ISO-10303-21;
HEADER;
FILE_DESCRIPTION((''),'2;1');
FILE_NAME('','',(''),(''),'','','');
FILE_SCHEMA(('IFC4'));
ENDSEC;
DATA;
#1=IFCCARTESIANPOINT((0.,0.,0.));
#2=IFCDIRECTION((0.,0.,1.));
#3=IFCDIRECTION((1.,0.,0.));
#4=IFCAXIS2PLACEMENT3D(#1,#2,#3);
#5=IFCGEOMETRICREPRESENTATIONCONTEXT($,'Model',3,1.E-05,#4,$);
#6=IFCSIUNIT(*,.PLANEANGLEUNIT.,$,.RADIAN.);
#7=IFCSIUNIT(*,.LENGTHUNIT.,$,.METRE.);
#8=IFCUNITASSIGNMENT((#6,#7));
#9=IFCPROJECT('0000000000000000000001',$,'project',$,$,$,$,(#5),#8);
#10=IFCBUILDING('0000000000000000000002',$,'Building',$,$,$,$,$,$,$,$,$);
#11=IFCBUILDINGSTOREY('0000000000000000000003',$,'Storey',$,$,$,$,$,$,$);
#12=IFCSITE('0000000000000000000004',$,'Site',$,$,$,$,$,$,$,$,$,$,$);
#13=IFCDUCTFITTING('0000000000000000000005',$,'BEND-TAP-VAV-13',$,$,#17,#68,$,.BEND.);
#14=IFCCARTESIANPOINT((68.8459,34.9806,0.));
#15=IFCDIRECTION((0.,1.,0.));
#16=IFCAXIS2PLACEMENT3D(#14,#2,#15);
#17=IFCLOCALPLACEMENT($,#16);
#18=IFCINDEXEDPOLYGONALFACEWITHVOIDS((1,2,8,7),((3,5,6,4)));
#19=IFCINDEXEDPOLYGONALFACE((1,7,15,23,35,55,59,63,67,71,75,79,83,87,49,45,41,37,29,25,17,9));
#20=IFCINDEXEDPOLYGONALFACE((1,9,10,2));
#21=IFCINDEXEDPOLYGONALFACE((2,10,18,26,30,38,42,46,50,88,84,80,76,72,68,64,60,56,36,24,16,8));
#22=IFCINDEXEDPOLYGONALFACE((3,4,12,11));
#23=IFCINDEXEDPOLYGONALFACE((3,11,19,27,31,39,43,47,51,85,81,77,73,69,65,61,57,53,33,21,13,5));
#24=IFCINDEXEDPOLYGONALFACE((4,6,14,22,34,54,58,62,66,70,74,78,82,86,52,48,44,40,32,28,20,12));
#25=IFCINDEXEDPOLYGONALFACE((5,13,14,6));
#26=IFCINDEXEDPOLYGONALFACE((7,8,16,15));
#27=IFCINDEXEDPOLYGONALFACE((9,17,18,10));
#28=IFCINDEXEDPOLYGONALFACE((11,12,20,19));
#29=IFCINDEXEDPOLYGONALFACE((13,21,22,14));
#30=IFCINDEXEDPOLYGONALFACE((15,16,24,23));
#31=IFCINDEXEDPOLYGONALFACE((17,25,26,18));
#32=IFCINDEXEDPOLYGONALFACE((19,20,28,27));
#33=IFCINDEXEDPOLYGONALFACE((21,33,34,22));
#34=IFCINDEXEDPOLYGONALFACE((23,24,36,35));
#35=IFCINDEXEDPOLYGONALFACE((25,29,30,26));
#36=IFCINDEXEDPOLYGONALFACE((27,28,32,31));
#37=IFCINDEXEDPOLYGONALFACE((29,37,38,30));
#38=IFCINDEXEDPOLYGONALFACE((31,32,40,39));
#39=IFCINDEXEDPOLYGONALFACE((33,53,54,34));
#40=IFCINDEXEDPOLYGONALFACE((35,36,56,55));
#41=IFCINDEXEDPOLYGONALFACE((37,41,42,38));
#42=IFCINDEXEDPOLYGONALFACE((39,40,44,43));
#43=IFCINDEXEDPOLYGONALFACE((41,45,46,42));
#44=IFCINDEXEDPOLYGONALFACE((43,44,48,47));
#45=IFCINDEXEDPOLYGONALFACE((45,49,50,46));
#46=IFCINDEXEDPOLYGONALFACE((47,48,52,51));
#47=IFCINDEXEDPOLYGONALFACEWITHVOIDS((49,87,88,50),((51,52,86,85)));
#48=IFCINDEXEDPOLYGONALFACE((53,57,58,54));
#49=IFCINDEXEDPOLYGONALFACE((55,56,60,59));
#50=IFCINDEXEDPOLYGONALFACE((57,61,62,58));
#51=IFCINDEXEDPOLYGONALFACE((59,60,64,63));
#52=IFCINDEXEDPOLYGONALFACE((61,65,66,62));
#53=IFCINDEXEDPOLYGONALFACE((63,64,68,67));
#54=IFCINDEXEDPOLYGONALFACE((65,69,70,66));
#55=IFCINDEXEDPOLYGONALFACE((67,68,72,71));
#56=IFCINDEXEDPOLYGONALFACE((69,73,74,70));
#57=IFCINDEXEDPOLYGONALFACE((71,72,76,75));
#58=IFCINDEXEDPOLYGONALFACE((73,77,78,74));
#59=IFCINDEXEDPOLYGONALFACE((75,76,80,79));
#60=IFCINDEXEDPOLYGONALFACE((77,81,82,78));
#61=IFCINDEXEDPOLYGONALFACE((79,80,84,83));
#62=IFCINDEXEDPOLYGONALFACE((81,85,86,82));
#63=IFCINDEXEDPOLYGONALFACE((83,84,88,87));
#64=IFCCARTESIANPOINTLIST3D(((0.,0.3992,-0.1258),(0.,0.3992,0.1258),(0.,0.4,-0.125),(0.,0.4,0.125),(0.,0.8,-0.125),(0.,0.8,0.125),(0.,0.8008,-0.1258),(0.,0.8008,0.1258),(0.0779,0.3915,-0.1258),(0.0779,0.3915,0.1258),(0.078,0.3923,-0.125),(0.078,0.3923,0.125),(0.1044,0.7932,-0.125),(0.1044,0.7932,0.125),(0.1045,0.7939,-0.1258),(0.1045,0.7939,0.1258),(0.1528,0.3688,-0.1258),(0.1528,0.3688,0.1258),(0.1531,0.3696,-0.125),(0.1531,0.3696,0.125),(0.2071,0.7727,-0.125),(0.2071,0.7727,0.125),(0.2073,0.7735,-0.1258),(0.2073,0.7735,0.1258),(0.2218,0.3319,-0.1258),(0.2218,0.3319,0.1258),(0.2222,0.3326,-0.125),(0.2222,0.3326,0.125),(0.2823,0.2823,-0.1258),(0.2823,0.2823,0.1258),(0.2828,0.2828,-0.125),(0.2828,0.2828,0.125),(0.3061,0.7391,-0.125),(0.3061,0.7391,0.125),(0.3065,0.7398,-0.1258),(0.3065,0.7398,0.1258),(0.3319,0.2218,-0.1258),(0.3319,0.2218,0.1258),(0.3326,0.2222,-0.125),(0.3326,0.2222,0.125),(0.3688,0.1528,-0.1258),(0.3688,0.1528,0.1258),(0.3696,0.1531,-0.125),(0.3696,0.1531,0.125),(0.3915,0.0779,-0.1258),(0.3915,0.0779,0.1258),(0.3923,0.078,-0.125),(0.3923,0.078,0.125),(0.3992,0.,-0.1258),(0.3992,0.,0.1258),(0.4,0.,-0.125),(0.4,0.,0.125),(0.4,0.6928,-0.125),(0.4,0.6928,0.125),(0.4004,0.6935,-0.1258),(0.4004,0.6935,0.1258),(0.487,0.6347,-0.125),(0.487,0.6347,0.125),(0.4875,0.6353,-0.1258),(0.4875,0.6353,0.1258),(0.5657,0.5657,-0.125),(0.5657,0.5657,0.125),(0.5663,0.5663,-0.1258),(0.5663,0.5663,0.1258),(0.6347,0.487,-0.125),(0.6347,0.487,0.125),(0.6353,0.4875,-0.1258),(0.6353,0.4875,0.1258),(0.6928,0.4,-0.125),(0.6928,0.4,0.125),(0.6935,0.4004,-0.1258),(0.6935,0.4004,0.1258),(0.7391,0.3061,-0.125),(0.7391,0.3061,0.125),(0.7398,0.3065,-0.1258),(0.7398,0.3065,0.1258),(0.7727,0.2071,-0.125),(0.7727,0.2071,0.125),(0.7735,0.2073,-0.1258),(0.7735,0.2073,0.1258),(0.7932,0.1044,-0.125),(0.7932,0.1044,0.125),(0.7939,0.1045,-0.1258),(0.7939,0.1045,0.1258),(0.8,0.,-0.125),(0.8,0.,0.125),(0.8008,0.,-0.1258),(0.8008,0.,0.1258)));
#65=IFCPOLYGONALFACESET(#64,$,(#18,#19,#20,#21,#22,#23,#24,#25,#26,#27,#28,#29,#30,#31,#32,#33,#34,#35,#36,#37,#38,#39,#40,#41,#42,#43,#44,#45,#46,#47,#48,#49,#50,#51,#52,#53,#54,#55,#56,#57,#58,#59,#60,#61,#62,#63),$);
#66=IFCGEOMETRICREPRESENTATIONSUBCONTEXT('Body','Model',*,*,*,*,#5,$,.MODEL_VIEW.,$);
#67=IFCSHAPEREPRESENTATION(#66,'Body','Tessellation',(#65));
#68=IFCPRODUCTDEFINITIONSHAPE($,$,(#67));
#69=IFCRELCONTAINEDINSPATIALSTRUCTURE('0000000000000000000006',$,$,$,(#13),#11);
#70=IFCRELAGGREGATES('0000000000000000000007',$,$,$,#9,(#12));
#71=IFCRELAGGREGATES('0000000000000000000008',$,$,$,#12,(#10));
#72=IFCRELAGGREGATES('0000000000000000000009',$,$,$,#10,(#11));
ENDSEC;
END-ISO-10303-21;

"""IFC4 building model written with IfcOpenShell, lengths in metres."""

from ifc_helpers import new_model, entity, si_unit, frame, origin_with_axes, place, context, subcontext, project, spatial, element, save


model = new_model("IFC4")

# Units and contexts
model_context = context("Model", 3, precision=1e-05, world=origin_with_axes())
body_context = subcontext(model_context, "Body", "Model", "MODEL_VIEW")
ifc_project = project(units=[si_unit("PLANEANGLEUNIT", "RADIAN"), si_unit("LENGTHUNIT", "METRE")], contexts=[model_context])

# Site, building, storey
site = spatial("IfcSite", under=ifc_project, Name="Site")
building = spatial("IfcBuilding", under=site, Name="Building")
storey = spatial("IfcBuildingStorey", under=building, Name="Storey")

# Duct fitting
duct_fitting_1_placement = place(None, frame((68.8459, 34.9806, 0.0), z_axis=(0.0, 0.0, 1.0), x_axis=(0.0, 1.0, 0.0)))
cartesian_point_1 = entity("IfcCartesianPoint", [0.0, 0.0, 0.0])
element("IfcDuctFitting", 1, at=duct_fitting_1_placement, inside=storey, Name="BEND-TAP-VAV-13", PredefinedType="BEND", context=body_context, shape_type="SweptSolid", body=[
    entity("IfcRevolvedAreaSolid", entity("IfcRectangleHollowProfileDef", "AREA", None, entity("IfcAxis2Placement2D", entity("IfcCartesianPoint", [0.6, 0.0])), 0.4016, 0.2516, 0.0008), entity("IfcAxis2Placement3D", cartesian_point_1, entity("IfcDirection", [0.0, -1.0, 0.0]), entity("IfcDirection", [1.0, 0.0, 0.0])), entity("IfcAxis1Placement", cartesian_point_1, entity("IfcDirection", [0.0, 1.0, 0.0])), 1.570796),
])

save(model, "model.ifc")
